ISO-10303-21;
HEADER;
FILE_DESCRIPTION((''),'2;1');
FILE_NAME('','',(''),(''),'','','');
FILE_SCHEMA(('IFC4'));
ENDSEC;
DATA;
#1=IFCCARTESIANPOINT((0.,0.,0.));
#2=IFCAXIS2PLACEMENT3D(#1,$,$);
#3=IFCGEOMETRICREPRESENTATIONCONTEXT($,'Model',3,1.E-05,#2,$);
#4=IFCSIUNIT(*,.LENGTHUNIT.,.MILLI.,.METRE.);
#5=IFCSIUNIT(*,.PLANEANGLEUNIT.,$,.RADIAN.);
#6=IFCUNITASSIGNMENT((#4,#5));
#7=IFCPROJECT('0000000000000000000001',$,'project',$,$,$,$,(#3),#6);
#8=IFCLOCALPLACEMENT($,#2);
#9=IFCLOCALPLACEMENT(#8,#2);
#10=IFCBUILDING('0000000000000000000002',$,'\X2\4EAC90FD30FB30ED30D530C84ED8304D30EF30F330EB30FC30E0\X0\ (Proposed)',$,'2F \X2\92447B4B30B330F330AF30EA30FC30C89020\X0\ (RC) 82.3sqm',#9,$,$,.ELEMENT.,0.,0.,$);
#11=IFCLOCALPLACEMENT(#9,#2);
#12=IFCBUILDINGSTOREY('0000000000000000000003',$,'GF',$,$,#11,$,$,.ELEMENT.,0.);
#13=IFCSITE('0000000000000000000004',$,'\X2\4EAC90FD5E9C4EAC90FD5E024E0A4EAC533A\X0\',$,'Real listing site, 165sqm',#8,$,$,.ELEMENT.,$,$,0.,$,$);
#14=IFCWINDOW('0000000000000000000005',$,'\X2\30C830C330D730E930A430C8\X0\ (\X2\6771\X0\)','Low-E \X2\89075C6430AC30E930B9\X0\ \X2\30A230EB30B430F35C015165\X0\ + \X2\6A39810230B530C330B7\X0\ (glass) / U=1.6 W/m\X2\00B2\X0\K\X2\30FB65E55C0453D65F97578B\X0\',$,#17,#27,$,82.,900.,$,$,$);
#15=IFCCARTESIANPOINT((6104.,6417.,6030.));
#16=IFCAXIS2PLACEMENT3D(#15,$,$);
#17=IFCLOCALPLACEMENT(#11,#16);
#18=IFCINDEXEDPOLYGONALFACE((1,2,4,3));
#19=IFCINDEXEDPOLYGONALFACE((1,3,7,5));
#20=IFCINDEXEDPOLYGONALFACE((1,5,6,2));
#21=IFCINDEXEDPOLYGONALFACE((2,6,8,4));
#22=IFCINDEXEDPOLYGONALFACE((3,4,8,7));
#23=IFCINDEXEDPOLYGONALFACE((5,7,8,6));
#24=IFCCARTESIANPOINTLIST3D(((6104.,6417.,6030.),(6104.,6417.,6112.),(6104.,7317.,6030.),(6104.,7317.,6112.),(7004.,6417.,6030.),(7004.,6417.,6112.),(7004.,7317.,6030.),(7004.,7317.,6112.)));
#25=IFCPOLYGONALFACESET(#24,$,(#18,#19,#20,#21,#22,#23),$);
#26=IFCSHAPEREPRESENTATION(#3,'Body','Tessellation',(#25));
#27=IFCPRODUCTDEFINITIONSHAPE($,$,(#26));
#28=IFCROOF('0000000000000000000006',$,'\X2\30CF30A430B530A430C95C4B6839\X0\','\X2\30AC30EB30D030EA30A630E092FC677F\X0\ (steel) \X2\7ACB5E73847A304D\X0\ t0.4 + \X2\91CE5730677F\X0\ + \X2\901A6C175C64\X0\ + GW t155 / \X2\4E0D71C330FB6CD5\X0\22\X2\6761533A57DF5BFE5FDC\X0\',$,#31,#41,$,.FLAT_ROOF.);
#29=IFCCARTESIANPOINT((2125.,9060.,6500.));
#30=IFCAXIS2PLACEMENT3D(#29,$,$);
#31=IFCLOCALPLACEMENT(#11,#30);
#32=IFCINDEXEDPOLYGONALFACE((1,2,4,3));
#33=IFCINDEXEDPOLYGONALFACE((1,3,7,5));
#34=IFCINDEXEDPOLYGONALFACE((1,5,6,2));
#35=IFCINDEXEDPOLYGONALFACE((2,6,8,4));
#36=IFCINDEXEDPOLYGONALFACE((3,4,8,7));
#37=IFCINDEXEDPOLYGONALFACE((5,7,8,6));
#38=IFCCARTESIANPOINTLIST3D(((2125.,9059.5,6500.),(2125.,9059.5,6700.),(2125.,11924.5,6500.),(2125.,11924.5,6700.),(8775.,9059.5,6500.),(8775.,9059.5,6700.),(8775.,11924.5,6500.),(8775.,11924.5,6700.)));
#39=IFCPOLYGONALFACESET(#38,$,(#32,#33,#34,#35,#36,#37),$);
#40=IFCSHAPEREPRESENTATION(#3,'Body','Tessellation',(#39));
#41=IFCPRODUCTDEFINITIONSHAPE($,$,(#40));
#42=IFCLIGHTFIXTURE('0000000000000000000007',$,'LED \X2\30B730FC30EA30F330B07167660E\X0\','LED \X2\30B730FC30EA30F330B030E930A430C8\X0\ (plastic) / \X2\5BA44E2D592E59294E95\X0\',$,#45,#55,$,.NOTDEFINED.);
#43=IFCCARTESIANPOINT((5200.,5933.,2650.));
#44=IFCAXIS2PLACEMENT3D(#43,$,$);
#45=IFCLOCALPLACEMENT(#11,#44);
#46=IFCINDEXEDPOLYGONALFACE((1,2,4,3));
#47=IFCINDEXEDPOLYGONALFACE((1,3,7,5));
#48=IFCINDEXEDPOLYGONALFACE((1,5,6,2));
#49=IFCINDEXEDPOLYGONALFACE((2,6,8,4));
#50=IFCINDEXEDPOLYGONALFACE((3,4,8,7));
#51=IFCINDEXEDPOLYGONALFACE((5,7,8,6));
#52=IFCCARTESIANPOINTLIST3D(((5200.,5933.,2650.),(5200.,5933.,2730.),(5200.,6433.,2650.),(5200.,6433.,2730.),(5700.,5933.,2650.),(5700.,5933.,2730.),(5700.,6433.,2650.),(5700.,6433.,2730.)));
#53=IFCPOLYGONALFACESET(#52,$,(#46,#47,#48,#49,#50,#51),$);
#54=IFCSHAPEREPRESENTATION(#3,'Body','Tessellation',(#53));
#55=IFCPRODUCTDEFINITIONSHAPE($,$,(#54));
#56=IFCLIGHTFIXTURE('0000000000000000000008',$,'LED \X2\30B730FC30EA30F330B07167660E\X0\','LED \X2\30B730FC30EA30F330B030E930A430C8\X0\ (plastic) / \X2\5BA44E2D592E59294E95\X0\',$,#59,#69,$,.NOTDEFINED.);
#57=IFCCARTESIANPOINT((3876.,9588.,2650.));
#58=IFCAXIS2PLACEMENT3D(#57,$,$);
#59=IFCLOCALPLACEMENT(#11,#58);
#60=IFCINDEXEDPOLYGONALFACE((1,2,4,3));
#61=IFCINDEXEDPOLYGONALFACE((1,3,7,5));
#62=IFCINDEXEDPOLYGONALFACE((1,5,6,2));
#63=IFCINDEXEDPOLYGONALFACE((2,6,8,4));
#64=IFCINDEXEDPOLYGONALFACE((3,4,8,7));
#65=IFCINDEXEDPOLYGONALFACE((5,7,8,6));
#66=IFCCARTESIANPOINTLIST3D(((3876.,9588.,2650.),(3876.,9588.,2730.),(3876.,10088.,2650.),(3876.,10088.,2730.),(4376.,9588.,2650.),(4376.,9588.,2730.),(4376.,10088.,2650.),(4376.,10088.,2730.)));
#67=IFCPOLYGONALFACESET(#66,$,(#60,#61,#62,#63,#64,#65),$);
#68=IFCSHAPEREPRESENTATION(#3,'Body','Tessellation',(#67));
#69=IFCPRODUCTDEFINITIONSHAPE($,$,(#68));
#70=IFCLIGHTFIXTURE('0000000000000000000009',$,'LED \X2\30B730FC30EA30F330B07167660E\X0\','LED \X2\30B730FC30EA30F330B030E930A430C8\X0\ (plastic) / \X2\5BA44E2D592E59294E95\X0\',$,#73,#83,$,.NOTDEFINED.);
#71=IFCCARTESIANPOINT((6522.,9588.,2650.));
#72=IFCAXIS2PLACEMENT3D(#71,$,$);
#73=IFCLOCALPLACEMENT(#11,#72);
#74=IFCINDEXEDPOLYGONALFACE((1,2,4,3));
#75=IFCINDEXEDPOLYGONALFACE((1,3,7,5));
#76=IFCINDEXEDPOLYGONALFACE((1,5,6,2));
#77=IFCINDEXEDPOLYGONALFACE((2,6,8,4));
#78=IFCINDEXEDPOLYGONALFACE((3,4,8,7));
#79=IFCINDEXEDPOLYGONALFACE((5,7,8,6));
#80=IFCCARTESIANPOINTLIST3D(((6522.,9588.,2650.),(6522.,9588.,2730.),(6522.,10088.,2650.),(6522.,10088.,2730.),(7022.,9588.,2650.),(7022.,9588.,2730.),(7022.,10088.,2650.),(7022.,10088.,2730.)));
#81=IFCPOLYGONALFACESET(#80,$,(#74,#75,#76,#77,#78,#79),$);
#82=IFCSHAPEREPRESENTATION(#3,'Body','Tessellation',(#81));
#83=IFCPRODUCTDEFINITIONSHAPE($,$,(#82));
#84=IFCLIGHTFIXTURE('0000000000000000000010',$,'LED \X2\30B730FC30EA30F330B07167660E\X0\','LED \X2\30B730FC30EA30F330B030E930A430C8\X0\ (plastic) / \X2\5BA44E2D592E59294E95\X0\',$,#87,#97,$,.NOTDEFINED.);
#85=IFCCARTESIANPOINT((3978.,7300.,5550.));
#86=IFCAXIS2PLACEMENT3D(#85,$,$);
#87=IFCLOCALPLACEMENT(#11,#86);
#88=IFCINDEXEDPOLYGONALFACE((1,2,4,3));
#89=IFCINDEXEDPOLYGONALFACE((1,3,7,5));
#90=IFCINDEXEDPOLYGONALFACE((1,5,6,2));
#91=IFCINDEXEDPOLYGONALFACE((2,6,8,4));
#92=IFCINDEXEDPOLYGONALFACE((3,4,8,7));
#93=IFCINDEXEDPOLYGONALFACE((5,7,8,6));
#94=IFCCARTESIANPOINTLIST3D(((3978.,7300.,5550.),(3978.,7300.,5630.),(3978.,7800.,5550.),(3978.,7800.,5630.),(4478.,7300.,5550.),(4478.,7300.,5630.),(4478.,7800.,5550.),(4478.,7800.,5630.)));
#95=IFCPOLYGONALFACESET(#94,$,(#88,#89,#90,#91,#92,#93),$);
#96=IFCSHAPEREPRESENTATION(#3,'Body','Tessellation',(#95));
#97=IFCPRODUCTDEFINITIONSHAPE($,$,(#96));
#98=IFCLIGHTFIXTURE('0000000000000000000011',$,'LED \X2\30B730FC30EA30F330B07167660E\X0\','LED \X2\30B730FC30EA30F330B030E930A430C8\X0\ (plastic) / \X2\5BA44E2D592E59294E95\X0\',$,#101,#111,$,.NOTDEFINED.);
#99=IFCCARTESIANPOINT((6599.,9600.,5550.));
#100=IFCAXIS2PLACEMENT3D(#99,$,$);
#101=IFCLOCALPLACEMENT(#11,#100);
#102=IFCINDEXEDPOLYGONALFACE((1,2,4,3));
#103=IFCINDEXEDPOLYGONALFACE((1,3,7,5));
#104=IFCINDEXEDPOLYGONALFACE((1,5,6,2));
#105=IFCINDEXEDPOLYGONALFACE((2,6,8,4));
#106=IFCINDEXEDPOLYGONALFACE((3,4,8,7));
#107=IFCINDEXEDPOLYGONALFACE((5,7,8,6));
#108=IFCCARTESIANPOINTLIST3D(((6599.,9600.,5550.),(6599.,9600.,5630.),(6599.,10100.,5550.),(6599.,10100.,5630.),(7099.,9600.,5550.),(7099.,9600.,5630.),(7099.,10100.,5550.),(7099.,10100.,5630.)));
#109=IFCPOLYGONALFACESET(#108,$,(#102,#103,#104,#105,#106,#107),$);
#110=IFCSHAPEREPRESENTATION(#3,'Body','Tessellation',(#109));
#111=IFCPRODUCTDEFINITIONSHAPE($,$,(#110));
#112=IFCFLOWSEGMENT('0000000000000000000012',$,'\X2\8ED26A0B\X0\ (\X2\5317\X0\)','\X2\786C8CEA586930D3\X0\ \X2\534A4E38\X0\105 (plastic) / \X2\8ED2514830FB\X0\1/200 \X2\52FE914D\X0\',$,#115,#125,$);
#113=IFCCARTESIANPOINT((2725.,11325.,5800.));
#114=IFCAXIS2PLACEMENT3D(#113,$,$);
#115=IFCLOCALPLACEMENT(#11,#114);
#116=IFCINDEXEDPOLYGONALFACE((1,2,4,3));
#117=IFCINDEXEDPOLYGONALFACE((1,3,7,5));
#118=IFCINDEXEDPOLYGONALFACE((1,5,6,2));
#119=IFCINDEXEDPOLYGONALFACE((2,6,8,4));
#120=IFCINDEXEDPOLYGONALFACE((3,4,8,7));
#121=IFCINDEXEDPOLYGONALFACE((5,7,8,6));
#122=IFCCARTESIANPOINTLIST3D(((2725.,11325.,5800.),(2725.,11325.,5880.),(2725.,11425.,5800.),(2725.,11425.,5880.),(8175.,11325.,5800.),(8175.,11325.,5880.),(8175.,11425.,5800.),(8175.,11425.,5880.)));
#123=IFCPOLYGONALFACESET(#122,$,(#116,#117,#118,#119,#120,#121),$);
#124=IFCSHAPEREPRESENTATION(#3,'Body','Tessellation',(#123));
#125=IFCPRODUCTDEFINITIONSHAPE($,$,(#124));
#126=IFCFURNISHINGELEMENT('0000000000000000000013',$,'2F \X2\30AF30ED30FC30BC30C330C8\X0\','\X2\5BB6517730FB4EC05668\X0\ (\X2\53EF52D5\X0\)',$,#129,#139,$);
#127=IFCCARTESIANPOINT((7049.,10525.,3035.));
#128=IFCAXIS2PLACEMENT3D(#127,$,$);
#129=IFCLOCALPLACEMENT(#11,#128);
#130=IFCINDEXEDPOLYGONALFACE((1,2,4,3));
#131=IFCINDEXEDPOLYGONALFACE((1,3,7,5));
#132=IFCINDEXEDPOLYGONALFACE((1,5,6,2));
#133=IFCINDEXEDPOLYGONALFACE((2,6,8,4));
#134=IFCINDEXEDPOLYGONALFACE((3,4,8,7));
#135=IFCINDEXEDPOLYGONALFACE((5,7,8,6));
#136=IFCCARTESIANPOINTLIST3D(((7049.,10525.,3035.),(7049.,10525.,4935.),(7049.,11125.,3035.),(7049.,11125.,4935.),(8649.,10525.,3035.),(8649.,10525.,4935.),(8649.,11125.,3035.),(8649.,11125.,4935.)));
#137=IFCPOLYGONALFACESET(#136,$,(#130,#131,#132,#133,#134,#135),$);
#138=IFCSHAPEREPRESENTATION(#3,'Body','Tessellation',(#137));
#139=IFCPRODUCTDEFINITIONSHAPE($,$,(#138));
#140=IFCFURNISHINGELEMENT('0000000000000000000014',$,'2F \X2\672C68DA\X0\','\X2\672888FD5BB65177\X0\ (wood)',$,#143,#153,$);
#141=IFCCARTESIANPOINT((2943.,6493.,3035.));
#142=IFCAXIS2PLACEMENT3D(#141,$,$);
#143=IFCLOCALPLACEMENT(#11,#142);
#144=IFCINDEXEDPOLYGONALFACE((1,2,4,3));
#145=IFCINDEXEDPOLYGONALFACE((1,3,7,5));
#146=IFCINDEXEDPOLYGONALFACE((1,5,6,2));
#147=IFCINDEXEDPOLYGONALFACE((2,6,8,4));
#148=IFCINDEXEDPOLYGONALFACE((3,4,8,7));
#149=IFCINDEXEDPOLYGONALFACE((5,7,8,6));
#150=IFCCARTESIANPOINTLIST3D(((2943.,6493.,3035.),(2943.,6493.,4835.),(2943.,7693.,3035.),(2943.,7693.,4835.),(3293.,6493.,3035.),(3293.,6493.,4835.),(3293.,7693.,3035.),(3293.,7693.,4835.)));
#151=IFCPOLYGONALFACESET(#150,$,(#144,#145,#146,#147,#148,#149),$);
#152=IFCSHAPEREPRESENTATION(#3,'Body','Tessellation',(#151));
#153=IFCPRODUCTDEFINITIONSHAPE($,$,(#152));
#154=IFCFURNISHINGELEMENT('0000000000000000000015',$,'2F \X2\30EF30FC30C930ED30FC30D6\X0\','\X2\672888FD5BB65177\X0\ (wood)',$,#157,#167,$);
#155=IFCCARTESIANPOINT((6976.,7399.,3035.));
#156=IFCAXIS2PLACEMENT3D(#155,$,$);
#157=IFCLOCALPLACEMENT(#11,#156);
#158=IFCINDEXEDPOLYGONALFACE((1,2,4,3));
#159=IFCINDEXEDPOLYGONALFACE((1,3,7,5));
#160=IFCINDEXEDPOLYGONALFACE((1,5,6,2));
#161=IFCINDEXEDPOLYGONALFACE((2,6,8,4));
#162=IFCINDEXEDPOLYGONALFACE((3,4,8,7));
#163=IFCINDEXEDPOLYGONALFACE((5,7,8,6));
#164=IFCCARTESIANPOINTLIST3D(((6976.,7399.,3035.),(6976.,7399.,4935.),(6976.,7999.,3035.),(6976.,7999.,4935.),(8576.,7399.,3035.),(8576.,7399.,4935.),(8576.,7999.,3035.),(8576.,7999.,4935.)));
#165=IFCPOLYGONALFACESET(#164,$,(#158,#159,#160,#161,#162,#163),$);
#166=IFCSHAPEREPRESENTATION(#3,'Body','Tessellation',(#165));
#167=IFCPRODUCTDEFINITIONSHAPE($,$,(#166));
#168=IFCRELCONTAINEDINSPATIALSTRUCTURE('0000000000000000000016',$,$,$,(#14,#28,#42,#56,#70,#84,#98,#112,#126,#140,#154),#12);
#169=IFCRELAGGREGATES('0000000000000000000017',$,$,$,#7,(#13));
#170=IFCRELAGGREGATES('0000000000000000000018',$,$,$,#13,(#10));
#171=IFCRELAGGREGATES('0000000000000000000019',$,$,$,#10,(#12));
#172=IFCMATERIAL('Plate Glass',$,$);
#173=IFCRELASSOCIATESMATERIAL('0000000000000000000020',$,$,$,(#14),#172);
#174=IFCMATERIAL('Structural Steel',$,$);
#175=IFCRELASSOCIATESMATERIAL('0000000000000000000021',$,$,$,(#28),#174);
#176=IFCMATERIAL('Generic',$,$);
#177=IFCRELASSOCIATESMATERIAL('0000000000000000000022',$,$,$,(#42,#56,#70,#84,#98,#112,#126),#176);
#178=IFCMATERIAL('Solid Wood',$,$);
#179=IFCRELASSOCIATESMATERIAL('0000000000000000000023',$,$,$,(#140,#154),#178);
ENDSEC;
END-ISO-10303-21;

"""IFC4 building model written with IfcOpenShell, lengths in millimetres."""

from ifc_helpers import new_model, si_unit, frame, frame_2d, origin, place, context, project, spatial, rectangle, extrude, material, element, save


model = new_model("IFC4")

# Units and contexts
model_context = context("Model", 3, precision=1e-05, world=origin())
ifc_project = project(units=[si_unit("LENGTHUNIT", "METRE", prefix="MILLI"), si_unit("PLANEANGLEUNIT", "RADIAN")], contexts=[model_context])

# Site, building, storey
site_placement = place(None, origin())
site = spatial("IfcSite", under=ifc_project, at=site_placement, Name="京都府京都市上京区", ObjectType="Real listing site, 165sqm", CompositionType="ELEMENT", RefElevation=0.0)
building_placement = place(site_placement, origin())
building = spatial("IfcBuilding", under=site, at=building_placement, Name="京都・ロフト付きワンルーム (Proposed)", ObjectType="2F 鉄筋コンクリート造 (RC) 82.3sqm", CompositionType="ELEMENT", ElevationOfRefHeight=0.0, ElevationOfTerrain=0.0)
storey_placement = place(building_placement, origin())
storey = spatial("IfcBuildingStorey", under=building, at=storey_placement, Name="GF", CompositionType="ELEMENT", Elevation=0.0)

# Shared definitions
ifc_material_1 = material(Name="Solid Wood")

# Shared definitions
ifc_material_2 = material(Name="Plate Glass")

# Window
window_1_placement = place(storey_placement, frame((6104.0, 6417.0, 6030.0)))
element("IfcWindow", 1, at=window_1_placement, inside=storey, material=ifc_material_2, Name="トップライト (東)", Description="Low-E 複層ガラス アルゴン封入 + 樹脂サッシ (glass) / U=1.6 W/m²K・日射取得型", OverallHeight=82.0, OverallWidth=900.0, context=model_context, shape_type="SweptSolid", body=[
    extrude(rectangle(XDim=900.0, YDim=900.0, at=frame_2d((450.0, 450.0))), frame((6104.0, 6417.0, 6030.0)), (0.0, 0.0, 1.0), 82.0),
])

# Roof
ifc_material_3 = material(Name="Structural Steel")
roof_placement = place(storey_placement, frame((2125.0, 9060.0, 6500.0)))
element("IfcRoof", 2, at=roof_placement, inside=storey, material=ifc_material_3, Name="ハイサイド屋根", Description="ガルバリウム鋼板 (steel) 立平葺き t0.4 + 野地板 + 通気層 + GW t155 / 不燃・法22条区域対応", PredefinedType="FLAT_ROOF", context=model_context, shape_type="SweptSolid", body=[
    extrude(rectangle(XDim=6650.0, YDim=2865.0, at=frame_2d((3325.0, 1432.0))), frame((2125.0, 9060.0, 6500.0)), (0.0, 0.0, 1.0), 200.0),
])

# Light fixtures
ifc_material_4 = material(Name="Generic")
light_fixture_1_placement = place(storey_placement, frame((5200.0, 5933.0, 2650.0)))
element("IfcLightFixture", 3, at=light_fixture_1_placement, inside=storey, material=ifc_material_4, Name="LED シーリング照明", Description="LED シーリングライト (plastic) / 室中央天井", PredefinedType="NOTDEFINED", context=model_context, shape_type="SweptSolid", body=[
    extrude(rectangle(XDim=500.0, YDim=500.0, at=frame_2d((250.0, 250.0))), frame((5200.0, 5933.0, 2650.0)), (0.0, 0.0, 1.0), 80.0),
])
light_fixture_2_placement = place(storey_placement, frame((3876.0, 9588.0, 2650.0)))
element("IfcLightFixture", 4, at=light_fixture_2_placement, inside=storey, material=ifc_material_4, Name="LED シーリング照明", Description="LED シーリングライト (plastic) / 室中央天井", PredefinedType="NOTDEFINED", context=model_context, shape_type="SweptSolid", body=[
    extrude(rectangle(XDim=500.0, YDim=500.0, at=frame_2d((250.0, 250.0))), frame((3876.0, 9588.0, 2650.0)), (0.0, 0.0, 1.0), 80.0),
])
light_fixture_3_placement = place(storey_placement, frame((6522.0, 9588.0, 2650.0)))
element("IfcLightFixture", 5, at=light_fixture_3_placement, inside=storey, material=ifc_material_4, Name="LED シーリング照明", Description="LED シーリングライト (plastic) / 室中央天井", PredefinedType="NOTDEFINED", context=model_context, shape_type="SweptSolid", body=[
    extrude(rectangle(XDim=500.0, YDim=500.0, at=frame_2d((250.0, 250.0))), frame((6522.0, 9588.0, 2650.0)), (0.0, 0.0, 1.0), 80.0),
])
light_fixture_4_placement = place(storey_placement, frame((3978.0, 7300.0, 5550.0)))
element("IfcLightFixture", 6, at=light_fixture_4_placement, inside=storey, material=ifc_material_4, Name="LED シーリング照明", Description="LED シーリングライト (plastic) / 室中央天井", PredefinedType="NOTDEFINED", context=model_context, shape_type="SweptSolid", body=[
    extrude(rectangle(XDim=500.0, YDim=500.0, at=frame_2d((250.0, 250.0))), frame((3978.0, 7300.0, 5550.0)), (0.0, 0.0, 1.0), 80.0),
])
light_fixture_5_placement = place(storey_placement, frame((6599.0, 9600.0, 5550.0)))
element("IfcLightFixture", 7, at=light_fixture_5_placement, inside=storey, material=ifc_material_4, Name="LED シーリング照明", Description="LED シーリングライト (plastic) / 室中央天井", PredefinedType="NOTDEFINED", context=model_context, shape_type="SweptSolid", body=[
    extrude(rectangle(XDim=500.0, YDim=500.0, at=frame_2d((250.0, 250.0))), frame((6599.0, 9600.0, 5550.0)), (0.0, 0.0, 1.0), 80.0),
])

# Flow segment
flow_segment_placement = place(storey_placement, frame((2725.0, 11325.0, 5800.0)))
element("IfcFlowSegment", 8, at=flow_segment_placement, inside=storey, material=ifc_material_4, Name="軒樋 (北)", Description="硬質塩ビ 半丸105 (plastic) / 軒先・1/200 勾配", context=model_context, shape_type="SweptSolid", body=[
    extrude(rectangle(XDim=5450.0, YDim=100.0, at=frame_2d((2725.0, 50.0))), frame((2725.0, 11325.0, 5800.0)), (0.0, 0.0, 1.0), 80.0),
])

# Furnishing elements
furnishing_1_placement = place(storey_placement, frame((7049.0, 10525.0, 3035.0)))
element("IfcFurnishingElement", 9, at=furnishing_1_placement, inside=storey, material=ifc_material_4, Name="2F クローゼット", Description="家具・什器 (可動)", context=model_context, shape_type="SweptSolid", body=[
    extrude(rectangle(XDim=1600.0, YDim=600.0, at=frame_2d((800.0, 300.0))), frame((7049.0, 10525.0, 3035.0)), (0.0, 0.0, 1.0), 1900.0),
])
furnishing_2_placement = place(storey_placement, frame((2943.0, 6493.0, 3035.0)))
element("IfcFurnishingElement", 10, at=furnishing_2_placement, inside=storey, material=ifc_material_1, Name="2F 本棚", Description="木製家具 (wood)", context=model_context, shape_type="SweptSolid", body=[
    extrude(rectangle(XDim=350.0, YDim=1200.0, at=frame_2d((175.0, 600.0))), frame((2943.0, 6493.0, 3035.0)), (0.0, 0.0, 1.0), 1800.0),
])
furnishing_3_placement = place(storey_placement, frame((6976.0, 7399.0, 3035.0)))
element("IfcFurnishingElement", 11, at=furnishing_3_placement, inside=storey, material=ifc_material_1, Name="2F ワードローブ", Description="木製家具 (wood)", context=model_context, shape_type="SweptSolid", body=[
    extrude(rectangle(XDim=1600.0, YDim=600.0, at=frame_2d((800.0, 300.0))), frame((6976.0, 7399.0, 3035.0)), (0.0, 0.0, 1.0), 1900.0),
])

save(model, "model.ifc")
